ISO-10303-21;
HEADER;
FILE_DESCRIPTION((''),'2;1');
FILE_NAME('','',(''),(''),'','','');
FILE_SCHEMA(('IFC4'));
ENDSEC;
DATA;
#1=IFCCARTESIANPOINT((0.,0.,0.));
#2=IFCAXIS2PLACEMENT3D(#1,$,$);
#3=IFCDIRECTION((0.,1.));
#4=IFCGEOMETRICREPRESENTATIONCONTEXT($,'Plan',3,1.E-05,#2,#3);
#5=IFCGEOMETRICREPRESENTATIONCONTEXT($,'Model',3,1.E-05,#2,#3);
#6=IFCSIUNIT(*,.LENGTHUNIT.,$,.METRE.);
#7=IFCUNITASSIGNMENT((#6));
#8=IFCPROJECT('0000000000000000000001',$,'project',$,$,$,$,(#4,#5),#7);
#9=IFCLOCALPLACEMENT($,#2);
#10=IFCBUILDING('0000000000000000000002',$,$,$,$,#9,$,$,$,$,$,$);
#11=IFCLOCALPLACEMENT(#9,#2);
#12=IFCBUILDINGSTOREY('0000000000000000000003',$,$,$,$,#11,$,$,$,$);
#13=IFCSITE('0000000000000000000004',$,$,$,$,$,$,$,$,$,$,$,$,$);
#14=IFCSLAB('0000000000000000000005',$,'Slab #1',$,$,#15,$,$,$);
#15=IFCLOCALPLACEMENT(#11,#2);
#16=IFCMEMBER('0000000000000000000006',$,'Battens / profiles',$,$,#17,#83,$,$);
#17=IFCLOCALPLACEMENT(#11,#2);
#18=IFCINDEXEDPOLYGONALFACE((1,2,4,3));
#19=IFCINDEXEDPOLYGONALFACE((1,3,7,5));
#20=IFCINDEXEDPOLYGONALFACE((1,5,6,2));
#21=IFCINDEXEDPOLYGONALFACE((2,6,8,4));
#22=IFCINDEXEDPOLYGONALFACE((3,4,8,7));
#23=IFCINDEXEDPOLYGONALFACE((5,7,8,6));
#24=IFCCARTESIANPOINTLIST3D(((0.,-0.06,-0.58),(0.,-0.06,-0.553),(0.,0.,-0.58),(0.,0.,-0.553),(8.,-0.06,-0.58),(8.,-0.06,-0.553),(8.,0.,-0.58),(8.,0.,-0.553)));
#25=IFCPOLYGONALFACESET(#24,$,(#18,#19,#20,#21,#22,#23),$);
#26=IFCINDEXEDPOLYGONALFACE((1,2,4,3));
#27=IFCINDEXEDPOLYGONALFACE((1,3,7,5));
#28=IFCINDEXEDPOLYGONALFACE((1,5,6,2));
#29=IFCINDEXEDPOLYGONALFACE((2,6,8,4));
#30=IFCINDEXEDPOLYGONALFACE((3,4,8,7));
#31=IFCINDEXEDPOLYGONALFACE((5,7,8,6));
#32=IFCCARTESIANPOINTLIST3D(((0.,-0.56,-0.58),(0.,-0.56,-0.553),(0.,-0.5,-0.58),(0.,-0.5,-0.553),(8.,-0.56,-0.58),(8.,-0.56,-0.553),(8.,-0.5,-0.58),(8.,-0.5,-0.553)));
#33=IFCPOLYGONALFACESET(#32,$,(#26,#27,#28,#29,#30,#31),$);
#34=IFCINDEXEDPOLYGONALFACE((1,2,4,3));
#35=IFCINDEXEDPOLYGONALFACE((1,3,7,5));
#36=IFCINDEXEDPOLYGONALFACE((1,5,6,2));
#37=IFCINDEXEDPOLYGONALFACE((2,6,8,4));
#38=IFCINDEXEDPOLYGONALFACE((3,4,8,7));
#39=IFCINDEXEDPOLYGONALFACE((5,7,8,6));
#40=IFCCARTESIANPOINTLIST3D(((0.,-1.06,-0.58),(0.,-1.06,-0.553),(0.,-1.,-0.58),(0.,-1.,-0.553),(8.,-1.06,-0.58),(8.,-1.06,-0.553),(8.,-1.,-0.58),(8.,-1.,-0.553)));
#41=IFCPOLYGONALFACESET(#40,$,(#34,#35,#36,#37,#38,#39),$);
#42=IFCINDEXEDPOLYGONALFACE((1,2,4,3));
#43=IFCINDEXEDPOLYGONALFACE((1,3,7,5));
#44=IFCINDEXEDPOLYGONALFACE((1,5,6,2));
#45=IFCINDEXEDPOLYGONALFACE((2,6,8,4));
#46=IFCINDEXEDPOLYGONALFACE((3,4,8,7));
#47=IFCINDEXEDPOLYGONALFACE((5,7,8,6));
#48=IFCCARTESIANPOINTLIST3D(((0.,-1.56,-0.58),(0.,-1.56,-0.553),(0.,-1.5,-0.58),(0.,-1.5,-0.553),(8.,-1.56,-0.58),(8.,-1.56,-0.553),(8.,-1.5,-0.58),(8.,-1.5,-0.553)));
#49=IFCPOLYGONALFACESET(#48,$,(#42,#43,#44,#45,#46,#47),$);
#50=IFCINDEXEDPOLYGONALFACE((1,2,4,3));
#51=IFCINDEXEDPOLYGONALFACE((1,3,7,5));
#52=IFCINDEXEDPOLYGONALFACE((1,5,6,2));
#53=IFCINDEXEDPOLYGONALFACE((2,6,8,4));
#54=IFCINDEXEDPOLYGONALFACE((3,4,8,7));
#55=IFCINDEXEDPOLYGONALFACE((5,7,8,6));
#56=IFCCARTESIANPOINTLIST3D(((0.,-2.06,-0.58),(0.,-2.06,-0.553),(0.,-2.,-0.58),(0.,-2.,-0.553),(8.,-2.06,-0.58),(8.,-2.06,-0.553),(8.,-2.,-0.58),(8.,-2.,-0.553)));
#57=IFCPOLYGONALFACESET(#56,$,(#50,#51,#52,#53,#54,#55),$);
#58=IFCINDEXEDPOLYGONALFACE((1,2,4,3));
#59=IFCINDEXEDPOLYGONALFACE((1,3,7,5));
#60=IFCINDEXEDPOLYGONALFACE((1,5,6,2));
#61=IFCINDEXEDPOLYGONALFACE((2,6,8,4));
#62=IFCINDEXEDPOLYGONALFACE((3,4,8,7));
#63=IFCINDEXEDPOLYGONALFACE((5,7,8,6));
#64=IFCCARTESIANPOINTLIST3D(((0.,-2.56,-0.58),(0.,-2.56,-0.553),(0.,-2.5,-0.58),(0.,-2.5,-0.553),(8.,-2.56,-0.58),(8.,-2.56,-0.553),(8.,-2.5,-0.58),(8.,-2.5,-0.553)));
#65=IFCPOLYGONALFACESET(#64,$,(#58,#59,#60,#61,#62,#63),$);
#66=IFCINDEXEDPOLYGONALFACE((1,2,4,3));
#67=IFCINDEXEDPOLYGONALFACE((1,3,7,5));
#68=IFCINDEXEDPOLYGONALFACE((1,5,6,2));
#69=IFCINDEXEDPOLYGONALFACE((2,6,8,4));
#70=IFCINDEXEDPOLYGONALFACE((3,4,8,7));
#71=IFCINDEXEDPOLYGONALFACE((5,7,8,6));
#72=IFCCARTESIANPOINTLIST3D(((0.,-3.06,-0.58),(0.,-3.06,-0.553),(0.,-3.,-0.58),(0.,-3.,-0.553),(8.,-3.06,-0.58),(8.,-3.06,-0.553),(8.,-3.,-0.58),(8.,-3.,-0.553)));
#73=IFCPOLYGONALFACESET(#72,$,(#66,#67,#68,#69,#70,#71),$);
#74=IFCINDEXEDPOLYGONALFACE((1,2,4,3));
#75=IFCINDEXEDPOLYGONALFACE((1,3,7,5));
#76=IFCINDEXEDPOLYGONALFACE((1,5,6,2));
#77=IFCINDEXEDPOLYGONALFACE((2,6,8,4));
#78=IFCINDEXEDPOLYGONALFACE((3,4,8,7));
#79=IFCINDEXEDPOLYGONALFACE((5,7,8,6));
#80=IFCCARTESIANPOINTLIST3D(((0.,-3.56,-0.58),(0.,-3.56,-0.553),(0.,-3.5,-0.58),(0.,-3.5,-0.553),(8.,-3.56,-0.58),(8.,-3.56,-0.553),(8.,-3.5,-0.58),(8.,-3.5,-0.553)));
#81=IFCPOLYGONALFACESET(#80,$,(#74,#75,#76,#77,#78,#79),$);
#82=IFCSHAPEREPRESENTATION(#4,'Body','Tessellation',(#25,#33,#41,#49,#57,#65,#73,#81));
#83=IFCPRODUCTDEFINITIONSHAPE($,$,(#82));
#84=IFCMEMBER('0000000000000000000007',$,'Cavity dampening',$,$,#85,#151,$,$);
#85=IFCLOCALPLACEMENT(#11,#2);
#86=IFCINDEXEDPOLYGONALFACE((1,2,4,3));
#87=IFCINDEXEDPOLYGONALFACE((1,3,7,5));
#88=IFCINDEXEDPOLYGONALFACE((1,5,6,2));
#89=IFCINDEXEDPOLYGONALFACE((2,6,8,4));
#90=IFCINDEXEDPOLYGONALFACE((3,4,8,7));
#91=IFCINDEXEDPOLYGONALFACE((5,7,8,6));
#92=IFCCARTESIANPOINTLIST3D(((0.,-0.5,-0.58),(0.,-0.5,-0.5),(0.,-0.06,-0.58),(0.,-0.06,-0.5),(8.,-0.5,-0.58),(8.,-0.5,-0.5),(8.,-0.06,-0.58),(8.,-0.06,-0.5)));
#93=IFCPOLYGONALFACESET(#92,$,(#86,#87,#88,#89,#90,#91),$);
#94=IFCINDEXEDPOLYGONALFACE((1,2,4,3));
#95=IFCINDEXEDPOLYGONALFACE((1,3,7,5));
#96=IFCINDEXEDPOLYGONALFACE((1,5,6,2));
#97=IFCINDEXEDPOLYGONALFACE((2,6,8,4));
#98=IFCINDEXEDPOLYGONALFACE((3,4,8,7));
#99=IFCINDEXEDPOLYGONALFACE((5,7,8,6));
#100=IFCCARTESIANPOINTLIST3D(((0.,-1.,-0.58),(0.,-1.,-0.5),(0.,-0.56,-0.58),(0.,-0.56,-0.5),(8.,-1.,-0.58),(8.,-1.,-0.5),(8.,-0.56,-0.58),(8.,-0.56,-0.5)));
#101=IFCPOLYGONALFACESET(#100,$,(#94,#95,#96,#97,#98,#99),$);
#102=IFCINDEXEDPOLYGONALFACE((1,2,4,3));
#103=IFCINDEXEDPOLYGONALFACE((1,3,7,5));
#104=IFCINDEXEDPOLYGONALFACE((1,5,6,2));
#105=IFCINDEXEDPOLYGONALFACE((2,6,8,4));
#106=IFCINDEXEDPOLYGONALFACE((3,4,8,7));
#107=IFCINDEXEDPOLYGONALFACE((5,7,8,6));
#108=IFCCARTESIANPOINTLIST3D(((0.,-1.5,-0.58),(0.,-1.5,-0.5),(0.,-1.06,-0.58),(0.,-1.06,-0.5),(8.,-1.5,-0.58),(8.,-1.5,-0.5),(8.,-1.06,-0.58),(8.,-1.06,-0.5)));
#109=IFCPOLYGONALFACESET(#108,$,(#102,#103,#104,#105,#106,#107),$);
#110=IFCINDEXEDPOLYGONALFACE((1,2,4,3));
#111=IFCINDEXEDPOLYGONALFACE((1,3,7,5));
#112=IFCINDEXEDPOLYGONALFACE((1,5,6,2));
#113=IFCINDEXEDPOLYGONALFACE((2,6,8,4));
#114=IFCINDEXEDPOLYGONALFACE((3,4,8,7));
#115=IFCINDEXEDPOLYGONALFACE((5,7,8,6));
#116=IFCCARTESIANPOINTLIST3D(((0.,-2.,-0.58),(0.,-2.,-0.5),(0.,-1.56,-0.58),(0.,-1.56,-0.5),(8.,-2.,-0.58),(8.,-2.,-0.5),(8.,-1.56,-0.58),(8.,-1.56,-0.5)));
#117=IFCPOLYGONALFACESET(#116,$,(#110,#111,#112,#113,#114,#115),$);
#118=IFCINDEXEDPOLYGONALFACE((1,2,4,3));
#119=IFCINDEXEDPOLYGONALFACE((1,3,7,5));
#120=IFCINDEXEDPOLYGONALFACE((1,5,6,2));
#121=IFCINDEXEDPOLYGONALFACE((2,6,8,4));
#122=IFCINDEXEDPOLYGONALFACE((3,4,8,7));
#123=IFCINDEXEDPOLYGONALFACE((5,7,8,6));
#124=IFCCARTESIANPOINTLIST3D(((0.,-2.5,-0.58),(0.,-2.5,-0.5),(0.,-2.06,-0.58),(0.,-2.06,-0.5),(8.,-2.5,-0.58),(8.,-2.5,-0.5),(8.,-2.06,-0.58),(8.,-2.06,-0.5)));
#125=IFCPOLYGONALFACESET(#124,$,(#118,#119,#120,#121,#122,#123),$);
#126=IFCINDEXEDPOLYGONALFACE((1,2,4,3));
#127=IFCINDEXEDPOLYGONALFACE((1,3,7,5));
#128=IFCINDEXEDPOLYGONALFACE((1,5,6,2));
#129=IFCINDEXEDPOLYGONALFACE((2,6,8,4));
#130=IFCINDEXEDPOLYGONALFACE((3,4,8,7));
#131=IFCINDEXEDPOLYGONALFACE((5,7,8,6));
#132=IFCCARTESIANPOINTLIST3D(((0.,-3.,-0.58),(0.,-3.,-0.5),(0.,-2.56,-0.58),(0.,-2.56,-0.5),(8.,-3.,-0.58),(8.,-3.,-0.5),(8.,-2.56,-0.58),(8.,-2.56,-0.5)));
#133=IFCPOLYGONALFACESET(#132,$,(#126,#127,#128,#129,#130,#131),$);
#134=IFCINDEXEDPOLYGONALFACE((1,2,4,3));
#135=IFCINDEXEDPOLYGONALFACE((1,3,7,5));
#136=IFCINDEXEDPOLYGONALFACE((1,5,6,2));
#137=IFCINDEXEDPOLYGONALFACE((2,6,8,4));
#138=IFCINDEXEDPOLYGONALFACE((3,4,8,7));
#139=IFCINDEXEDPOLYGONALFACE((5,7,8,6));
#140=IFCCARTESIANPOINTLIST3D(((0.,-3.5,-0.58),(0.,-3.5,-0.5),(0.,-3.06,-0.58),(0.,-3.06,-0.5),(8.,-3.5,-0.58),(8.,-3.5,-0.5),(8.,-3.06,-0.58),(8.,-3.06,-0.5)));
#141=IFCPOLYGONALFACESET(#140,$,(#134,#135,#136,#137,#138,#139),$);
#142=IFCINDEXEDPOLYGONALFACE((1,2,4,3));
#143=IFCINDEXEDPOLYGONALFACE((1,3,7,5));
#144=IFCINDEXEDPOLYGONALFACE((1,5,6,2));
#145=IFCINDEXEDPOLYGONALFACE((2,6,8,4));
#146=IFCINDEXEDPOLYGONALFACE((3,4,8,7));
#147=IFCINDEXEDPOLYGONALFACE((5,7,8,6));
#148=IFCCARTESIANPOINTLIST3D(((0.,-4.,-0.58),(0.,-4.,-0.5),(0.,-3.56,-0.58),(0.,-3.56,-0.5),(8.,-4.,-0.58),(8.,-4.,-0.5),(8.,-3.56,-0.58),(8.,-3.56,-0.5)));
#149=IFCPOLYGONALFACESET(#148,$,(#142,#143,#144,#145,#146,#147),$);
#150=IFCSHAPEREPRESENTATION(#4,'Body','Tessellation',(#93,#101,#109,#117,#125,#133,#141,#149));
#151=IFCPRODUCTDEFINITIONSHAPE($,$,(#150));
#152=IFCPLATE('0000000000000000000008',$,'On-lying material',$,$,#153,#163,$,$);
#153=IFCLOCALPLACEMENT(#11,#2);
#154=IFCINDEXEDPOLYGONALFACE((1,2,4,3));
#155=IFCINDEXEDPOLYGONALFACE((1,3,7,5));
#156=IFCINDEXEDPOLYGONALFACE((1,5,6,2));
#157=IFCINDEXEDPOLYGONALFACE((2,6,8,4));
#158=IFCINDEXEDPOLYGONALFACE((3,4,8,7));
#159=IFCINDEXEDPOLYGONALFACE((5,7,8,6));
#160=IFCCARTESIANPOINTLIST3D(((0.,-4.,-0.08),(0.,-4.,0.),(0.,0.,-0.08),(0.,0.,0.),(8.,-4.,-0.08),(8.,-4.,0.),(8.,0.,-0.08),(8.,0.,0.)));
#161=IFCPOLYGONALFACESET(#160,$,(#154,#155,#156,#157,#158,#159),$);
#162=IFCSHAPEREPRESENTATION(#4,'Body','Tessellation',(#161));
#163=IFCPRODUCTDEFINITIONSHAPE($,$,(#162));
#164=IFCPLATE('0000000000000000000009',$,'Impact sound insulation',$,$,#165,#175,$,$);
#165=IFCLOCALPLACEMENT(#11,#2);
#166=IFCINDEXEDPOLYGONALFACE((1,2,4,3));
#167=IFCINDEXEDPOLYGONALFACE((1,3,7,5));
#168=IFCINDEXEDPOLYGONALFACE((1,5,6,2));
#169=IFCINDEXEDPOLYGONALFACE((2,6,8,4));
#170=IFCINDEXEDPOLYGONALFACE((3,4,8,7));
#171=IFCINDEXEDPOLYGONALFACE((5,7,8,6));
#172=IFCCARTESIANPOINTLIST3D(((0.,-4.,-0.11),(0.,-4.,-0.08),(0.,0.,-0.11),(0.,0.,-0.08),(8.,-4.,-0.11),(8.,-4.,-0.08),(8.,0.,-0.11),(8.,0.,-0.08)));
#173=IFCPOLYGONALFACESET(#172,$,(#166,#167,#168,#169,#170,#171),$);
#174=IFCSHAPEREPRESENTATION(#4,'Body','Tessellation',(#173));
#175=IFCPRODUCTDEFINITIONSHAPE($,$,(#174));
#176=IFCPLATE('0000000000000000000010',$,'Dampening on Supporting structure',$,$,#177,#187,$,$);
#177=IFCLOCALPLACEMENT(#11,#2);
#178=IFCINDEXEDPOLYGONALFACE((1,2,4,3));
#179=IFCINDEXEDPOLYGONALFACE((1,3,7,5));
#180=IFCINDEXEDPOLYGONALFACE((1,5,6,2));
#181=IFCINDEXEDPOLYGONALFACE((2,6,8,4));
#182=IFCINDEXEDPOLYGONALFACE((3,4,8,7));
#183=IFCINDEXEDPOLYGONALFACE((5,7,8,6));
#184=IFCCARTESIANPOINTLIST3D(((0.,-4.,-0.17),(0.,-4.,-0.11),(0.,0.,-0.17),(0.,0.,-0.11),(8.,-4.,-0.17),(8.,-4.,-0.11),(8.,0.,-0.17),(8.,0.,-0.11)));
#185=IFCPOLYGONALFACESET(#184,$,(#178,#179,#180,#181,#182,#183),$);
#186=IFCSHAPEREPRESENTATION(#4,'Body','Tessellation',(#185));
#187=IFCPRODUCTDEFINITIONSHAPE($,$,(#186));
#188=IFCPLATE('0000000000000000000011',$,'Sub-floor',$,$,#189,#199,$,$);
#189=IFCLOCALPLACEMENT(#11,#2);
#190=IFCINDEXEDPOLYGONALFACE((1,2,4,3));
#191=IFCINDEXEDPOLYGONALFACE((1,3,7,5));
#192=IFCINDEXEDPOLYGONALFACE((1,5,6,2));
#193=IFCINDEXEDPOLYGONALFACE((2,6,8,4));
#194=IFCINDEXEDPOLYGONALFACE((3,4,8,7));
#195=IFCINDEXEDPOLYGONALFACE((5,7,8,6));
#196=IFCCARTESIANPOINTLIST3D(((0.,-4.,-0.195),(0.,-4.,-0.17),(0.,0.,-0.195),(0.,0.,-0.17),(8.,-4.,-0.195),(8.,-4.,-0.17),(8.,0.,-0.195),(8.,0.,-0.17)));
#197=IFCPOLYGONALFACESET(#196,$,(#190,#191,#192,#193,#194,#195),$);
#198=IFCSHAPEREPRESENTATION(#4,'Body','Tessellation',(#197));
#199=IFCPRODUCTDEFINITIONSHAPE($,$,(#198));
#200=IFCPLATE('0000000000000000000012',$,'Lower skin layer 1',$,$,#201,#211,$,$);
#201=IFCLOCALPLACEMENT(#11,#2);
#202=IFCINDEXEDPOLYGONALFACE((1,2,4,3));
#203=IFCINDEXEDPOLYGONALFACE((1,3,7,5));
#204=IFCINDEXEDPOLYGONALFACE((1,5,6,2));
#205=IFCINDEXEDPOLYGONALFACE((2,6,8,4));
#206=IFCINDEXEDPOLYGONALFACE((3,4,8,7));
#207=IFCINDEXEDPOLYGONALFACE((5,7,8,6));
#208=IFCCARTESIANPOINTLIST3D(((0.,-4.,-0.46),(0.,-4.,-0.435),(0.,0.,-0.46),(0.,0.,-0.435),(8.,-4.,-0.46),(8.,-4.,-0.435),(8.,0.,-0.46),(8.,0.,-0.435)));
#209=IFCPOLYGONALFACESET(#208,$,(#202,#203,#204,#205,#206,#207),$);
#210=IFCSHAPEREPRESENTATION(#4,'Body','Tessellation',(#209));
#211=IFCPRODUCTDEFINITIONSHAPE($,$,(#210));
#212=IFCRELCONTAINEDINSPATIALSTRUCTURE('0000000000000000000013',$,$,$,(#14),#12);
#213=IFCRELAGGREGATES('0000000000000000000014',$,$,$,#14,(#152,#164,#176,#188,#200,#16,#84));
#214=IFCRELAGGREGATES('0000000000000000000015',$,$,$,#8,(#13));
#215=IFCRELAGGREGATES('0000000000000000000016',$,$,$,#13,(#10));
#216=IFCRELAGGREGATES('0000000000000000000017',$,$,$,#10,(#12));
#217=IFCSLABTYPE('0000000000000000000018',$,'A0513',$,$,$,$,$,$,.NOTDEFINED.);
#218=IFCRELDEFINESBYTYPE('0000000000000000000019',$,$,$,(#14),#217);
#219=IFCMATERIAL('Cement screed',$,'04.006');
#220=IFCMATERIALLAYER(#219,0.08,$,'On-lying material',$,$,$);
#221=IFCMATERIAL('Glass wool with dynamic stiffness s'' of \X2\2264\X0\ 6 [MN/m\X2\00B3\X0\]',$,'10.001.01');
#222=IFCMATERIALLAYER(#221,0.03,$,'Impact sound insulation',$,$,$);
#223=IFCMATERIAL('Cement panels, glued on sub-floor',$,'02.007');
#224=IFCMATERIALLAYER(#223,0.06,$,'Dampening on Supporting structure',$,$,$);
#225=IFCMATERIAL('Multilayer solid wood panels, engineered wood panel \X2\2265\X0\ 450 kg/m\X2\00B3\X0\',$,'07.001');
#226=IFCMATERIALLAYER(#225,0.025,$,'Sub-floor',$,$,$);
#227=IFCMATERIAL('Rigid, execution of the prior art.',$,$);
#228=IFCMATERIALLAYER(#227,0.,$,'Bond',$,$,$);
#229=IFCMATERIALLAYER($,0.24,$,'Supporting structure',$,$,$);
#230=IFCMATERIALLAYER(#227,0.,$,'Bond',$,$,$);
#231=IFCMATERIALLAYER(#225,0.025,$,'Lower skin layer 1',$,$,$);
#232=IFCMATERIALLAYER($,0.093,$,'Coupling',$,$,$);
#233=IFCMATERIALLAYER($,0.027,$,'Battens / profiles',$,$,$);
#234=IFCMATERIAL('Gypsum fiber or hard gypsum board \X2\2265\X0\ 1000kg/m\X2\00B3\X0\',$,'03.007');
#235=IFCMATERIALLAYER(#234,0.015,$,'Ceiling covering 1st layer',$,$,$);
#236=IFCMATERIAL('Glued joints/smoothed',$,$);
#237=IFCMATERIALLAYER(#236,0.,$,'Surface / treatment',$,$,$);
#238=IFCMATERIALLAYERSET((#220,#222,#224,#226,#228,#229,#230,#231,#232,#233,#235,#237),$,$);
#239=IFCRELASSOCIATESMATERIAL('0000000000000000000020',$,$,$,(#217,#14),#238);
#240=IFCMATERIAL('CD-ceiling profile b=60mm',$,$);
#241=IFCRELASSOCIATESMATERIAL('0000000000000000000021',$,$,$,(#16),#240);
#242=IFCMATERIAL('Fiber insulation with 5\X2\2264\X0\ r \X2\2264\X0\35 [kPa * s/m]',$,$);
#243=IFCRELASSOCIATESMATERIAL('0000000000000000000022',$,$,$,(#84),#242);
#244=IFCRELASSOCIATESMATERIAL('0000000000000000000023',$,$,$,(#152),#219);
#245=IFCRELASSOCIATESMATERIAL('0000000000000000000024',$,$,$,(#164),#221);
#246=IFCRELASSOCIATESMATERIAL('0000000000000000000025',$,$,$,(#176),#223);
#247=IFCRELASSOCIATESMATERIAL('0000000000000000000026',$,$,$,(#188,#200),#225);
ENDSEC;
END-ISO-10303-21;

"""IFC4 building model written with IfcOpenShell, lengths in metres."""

from ifc_helpers import new_model, si_unit, direction, frame, frame_2d, origin, origin_with_axes, place, context, project, spatial, rectangle, extrude, material, layer, layer_set, type_object, element, aggregate, save


model = new_model("IFC4")

# Units and contexts
plan_context = context("Plan", 3, precision=1e-05, world=origin(), true_north=direction((0.0, 1.0)))
model_context = context("Model", 3, precision=1e-05, world=origin(), true_north=direction((0.0, 1.0)))
ifc_project = project(units=[si_unit("LENGTHUNIT", "METRE")], contexts=[plan_context, model_context])

# Site, building, storey
site = spatial("IfcSite", under=ifc_project)
building_placement = place(None, origin())
building = spatial("IfcBuilding", under=site, at=building_placement)
storey_placement = place(building_placement, origin())
storey = spatial("IfcBuildingStorey", under=building, at=storey_placement)

# Slab, members, plates
ifc_material_1 = material(Name="Cement screed", Category="04.006")
ifc_layer_1 = layer(ifc_material_1, 0.08, Name="On-lying material")
ifc_material_2 = material(Name="Glass wool with dynamic stiffness s' of ≤ 6 [MN/m³]", Category="10.001.01")
ifc_layer_2 = layer(ifc_material_2, 0.03, Name="Impact sound insulation")
ifc_material_3 = material(Name="Cement panels, glued on sub-floor", Category="02.007")
ifc_layer_3 = layer(ifc_material_3, 0.06, Name="Dampening on Supporting structure")
ifc_material_4 = material(Name="Multilayer solid wood panels, engineered wood panel ≥ 450 kg/m³", Category="07.001")
ifc_layer_4 = layer(ifc_material_4, 0.025, Name="Sub-floor")
ifc_material_5 = material(Name="Rigid, execution of the prior art.")
ifc_layer_5 = layer(ifc_material_5, 0.0, Name="Bond")
ifc_layer_6 = layer(None, 0.24, Name="Supporting structure")
ifc_layer_7 = layer(ifc_material_5, 0.0, Name="Bond")
ifc_layer_8 = layer(ifc_material_4, 0.025, Name="Lower skin layer 1")
ifc_layer_9 = layer(None, 0.093, Name="Coupling")
ifc_layer_10 = layer(None, 0.027, Name="Battens / profiles")
ifc_material_6 = material(Name="Gypsum fiber or hard gypsum board ≥ 1000kg/m³", Category="03.007")
ifc_layer_11 = layer(ifc_material_6, 0.015, Name="Ceiling covering 1st layer")
ifc_material_7 = material(Name="Glued joints/smoothed")
ifc_layer_12 = layer(ifc_material_7, 0.0, Name="Surface / treatment")
ifc_layer_set = layer_set([ifc_layer_1, ifc_layer_2, ifc_layer_3, ifc_layer_4, ifc_layer_5, ifc_layer_6, ifc_layer_7, ifc_layer_8, ifc_layer_9, ifc_layer_10, ifc_layer_11, ifc_layer_12])
slab_type = type_object("IfcSlabType", Name="A0513", PredefinedType="NOTDEFINED", material=ifc_layer_set)
slab_placement = place(None, frame((0.0, 0.0, 0.0), z_axis=(0.0, 0.0, -1.0), x_axis=(1.0, 0.0, 0.0)))
slab = element("IfcSlab", 1, at=slab_placement, inside=storey, type_object=slab_type, material=ifc_layer_set, Name="Slab #1")
ifc_material_8 = material(Name="Fiber insulation with 5≤ r ≤35 [kPa * s/m]")
ifc_material_9 = material(Name="CD-ceiling profile b=60mm")
member_1_placement = place(slab_placement, origin())
member_1 = element("IfcMember", 2, at=member_1_placement, material=ifc_material_9, Name="Battens / profiles", context=plan_context, shape_type="SweptSolid", body=[
    extrude(rectangle(XDim=0.06, YDim=0.027, at=frame_2d((0.03, 0.0135), x_axis=(1.0, 0.0))), frame((0.0, 0.0, 0.553), z_axis=(1.0, 0.0, 0.0), x_axis=(0.0, 1.0, 0.0)), (0.0, 0.0, 1.0), 8.0),
    extrude(rectangle(XDim=0.06, YDim=0.027, at=frame_2d((0.03, 0.0135), x_axis=(1.0, 0.0))), frame((0.0, 0.5, 0.553), z_axis=(1.0, 0.0, 0.0), x_axis=(0.0, 1.0, 0.0)), (0.0, 0.0, 1.0), 8.0),
    extrude(rectangle(XDim=0.06, YDim=0.027, at=frame_2d((0.03, 0.0135), x_axis=(1.0, 0.0))), frame((0.0, 1.0, 0.553), z_axis=(1.0, 0.0, 0.0), x_axis=(0.0, 1.0, 0.0)), (0.0, 0.0, 1.0), 8.0),
    extrude(rectangle(XDim=0.06, YDim=0.027, at=frame_2d((0.03, 0.0135), x_axis=(1.0, 0.0))), frame((0.0, 1.5, 0.553), z_axis=(1.0, 0.0, 0.0), x_axis=(0.0, 1.0, 0.0)), (0.0, 0.0, 1.0), 8.0),
    extrude(rectangle(XDim=0.06, YDim=0.027, at=frame_2d((0.03, 0.0135), x_axis=(1.0, 0.0))), frame((0.0, 2.0, 0.553), z_axis=(1.0, 0.0, 0.0), x_axis=(0.0, 1.0, 0.0)), (0.0, 0.0, 1.0), 8.0),
    extrude(rectangle(XDim=0.06, YDim=0.027, at=frame_2d((0.03, 0.0135), x_axis=(1.0, 0.0))), frame((0.0, 2.5, 0.553), z_axis=(1.0, 0.0, 0.0), x_axis=(0.0, 1.0, 0.0)), (0.0, 0.0, 1.0), 8.0),
    extrude(rectangle(XDim=0.06, YDim=0.027, at=frame_2d((0.03, 0.0135), x_axis=(1.0, 0.0))), frame((0.0, 3.0, 0.553), z_axis=(1.0, 0.0, 0.0), x_axis=(0.0, 1.0, 0.0)), (0.0, 0.0, 1.0), 8.0),
    extrude(rectangle(XDim=0.06, YDim=0.027, at=frame_2d((0.03, 0.0135), x_axis=(1.0, 0.0))), frame((0.0, 3.5, 0.553), z_axis=(1.0, 0.0, 0.0), x_axis=(0.0, 1.0, 0.0)), (0.0, 0.0, 1.0), 8.0),
])
member_2_placement = place(slab_placement, origin())
member_2 = element("IfcMember", 3, at=member_2_placement, material=ifc_material_8, Name="Cavity dampening", context=plan_context, shape_type="SweptSolid", body=[
    extrude(rectangle(XDim=0.44, YDim=0.08, at=frame_2d((0.22, 0.04), x_axis=(1.0, 0.0))), frame((0.0, 0.06, 0.5), z_axis=(1.0, 0.0, 0.0), x_axis=(0.0, 1.0, 0.0)), (0.0, 0.0, 1.0), 8.0),
    extrude(rectangle(XDim=0.44, YDim=0.08, at=frame_2d((0.22, 0.04), x_axis=(1.0, 0.0))), frame((0.0, 0.56, 0.5), z_axis=(1.0, 0.0, 0.0), x_axis=(0.0, 1.0, 0.0)), (0.0, 0.0, 1.0), 8.0),
    extrude(rectangle(XDim=0.44, YDim=0.08, at=frame_2d((0.22, 0.04), x_axis=(1.0, 0.0))), frame((0.0, 1.06, 0.5), z_axis=(1.0, 0.0, 0.0), x_axis=(0.0, 1.0, 0.0)), (0.0, 0.0, 1.0), 8.0),
    extrude(rectangle(XDim=0.44, YDim=0.08, at=frame_2d((0.22, 0.04), x_axis=(1.0, 0.0))), frame((0.0, 1.56, 0.5), z_axis=(1.0, 0.0, 0.0), x_axis=(0.0, 1.0, 0.0)), (0.0, 0.0, 1.0), 8.0),
    extrude(rectangle(XDim=0.44, YDim=0.08, at=frame_2d((0.22, 0.04), x_axis=(1.0, 0.0))), frame((0.0, 2.06, 0.5), z_axis=(1.0, 0.0, 0.0), x_axis=(0.0, 1.0, 0.0)), (0.0, 0.0, 1.0), 8.0),
    extrude(rectangle(XDim=0.44, YDim=0.08, at=frame_2d((0.22, 0.04), x_axis=(1.0, 0.0))), frame((0.0, 2.56, 0.5), z_axis=(1.0, 0.0, 0.0), x_axis=(0.0, 1.0, 0.0)), (0.0, 0.0, 1.0), 8.0),
    extrude(rectangle(XDim=0.44, YDim=0.08, at=frame_2d((0.22, 0.04), x_axis=(1.0, 0.0))), frame((0.0, 3.06, 0.5), z_axis=(1.0, 0.0, 0.0), x_axis=(0.0, 1.0, 0.0)), (0.0, 0.0, 1.0), 8.0),
    extrude(rectangle(XDim=0.44, YDim=0.08, at=frame_2d((0.22, 0.04), x_axis=(1.0, 0.0))), frame((0.0, 3.56, 0.5), z_axis=(1.0, 0.0, 0.0), x_axis=(0.0, 1.0, 0.0)), (0.0, 0.0, 1.0), 8.0),
])
plate_1_placement = place(slab_placement, origin())
plate_1 = element("IfcPlate", 4, at=plate_1_placement, material=ifc_material_1, Name="On-lying material", context=plan_context, shape_type="SweptSolid", body=[
    extrude(rectangle(XDim=8.0, YDim=4.0, at=frame_2d((4.0, 2.0), x_axis=(1.0, 0.0))), origin_with_axes(), (0.0, 0.0, 1.0), 0.08),
])
plate_2_placement = place(slab_placement, origin())
plate_2 = element("IfcPlate", 5, at=plate_2_placement, material=ifc_material_2, Name="Impact sound insulation", context=plan_context, shape_type="SweptSolid", body=[
    extrude(rectangle(XDim=8.0, YDim=4.0, at=frame_2d((4.0, 2.0), x_axis=(1.0, 0.0))), frame((0.0, 0.0, 0.08), z_axis=(0.0, 0.0, 1.0), x_axis=(1.0, 0.0, 0.0)), (0.0, 0.0, 1.0), 0.03),
])
plate_3_placement = place(slab_placement, origin())
plate_3 = element("IfcPlate", 6, at=plate_3_placement, material=ifc_material_3, Name="Dampening on Supporting structure", context=plan_context, shape_type="SweptSolid", body=[
    extrude(rectangle(XDim=8.0, YDim=4.0, at=frame_2d((4.0, 2.0), x_axis=(1.0, 0.0))), frame((0.0, 0.0, 0.11), z_axis=(0.0, 0.0, 1.0), x_axis=(1.0, 0.0, 0.0)), (0.0, 0.0, 1.0), 0.06),
])
plate_4_placement = place(slab_placement, origin())
plate_4 = element("IfcPlate", 7, at=plate_4_placement, material=ifc_material_4, Name="Sub-floor", context=plan_context, shape_type="SweptSolid", body=[
    extrude(rectangle(XDim=8.0, YDim=4.0, at=frame_2d((4.0, 2.0), x_axis=(1.0, 0.0))), frame((0.0, 0.0, 0.17), z_axis=(0.0, 0.0, 1.0), x_axis=(1.0, 0.0, 0.0)), (0.0, 0.0, 1.0), 0.025),
])
plate_5_placement = place(slab_placement, origin())
plate_5 = element("IfcPlate", 8, at=plate_5_placement, material=ifc_material_4, Name="Lower skin layer 1", context=plan_context, shape_type="SweptSolid", body=[
    extrude(rectangle(XDim=8.0, YDim=4.0, at=frame_2d((4.0, 2.0), x_axis=(1.0, 0.0))), frame((0.0, 0.0, 0.435), z_axis=(0.0, 0.0, 1.0), x_axis=(1.0, 0.0, 0.0)), (0.0, 0.0, 1.0), 0.025),
])
aggregate(slab, [plate_1, plate_2, plate_3, plate_4, plate_5, member_1, member_2])

save(model, "model.ifc")
